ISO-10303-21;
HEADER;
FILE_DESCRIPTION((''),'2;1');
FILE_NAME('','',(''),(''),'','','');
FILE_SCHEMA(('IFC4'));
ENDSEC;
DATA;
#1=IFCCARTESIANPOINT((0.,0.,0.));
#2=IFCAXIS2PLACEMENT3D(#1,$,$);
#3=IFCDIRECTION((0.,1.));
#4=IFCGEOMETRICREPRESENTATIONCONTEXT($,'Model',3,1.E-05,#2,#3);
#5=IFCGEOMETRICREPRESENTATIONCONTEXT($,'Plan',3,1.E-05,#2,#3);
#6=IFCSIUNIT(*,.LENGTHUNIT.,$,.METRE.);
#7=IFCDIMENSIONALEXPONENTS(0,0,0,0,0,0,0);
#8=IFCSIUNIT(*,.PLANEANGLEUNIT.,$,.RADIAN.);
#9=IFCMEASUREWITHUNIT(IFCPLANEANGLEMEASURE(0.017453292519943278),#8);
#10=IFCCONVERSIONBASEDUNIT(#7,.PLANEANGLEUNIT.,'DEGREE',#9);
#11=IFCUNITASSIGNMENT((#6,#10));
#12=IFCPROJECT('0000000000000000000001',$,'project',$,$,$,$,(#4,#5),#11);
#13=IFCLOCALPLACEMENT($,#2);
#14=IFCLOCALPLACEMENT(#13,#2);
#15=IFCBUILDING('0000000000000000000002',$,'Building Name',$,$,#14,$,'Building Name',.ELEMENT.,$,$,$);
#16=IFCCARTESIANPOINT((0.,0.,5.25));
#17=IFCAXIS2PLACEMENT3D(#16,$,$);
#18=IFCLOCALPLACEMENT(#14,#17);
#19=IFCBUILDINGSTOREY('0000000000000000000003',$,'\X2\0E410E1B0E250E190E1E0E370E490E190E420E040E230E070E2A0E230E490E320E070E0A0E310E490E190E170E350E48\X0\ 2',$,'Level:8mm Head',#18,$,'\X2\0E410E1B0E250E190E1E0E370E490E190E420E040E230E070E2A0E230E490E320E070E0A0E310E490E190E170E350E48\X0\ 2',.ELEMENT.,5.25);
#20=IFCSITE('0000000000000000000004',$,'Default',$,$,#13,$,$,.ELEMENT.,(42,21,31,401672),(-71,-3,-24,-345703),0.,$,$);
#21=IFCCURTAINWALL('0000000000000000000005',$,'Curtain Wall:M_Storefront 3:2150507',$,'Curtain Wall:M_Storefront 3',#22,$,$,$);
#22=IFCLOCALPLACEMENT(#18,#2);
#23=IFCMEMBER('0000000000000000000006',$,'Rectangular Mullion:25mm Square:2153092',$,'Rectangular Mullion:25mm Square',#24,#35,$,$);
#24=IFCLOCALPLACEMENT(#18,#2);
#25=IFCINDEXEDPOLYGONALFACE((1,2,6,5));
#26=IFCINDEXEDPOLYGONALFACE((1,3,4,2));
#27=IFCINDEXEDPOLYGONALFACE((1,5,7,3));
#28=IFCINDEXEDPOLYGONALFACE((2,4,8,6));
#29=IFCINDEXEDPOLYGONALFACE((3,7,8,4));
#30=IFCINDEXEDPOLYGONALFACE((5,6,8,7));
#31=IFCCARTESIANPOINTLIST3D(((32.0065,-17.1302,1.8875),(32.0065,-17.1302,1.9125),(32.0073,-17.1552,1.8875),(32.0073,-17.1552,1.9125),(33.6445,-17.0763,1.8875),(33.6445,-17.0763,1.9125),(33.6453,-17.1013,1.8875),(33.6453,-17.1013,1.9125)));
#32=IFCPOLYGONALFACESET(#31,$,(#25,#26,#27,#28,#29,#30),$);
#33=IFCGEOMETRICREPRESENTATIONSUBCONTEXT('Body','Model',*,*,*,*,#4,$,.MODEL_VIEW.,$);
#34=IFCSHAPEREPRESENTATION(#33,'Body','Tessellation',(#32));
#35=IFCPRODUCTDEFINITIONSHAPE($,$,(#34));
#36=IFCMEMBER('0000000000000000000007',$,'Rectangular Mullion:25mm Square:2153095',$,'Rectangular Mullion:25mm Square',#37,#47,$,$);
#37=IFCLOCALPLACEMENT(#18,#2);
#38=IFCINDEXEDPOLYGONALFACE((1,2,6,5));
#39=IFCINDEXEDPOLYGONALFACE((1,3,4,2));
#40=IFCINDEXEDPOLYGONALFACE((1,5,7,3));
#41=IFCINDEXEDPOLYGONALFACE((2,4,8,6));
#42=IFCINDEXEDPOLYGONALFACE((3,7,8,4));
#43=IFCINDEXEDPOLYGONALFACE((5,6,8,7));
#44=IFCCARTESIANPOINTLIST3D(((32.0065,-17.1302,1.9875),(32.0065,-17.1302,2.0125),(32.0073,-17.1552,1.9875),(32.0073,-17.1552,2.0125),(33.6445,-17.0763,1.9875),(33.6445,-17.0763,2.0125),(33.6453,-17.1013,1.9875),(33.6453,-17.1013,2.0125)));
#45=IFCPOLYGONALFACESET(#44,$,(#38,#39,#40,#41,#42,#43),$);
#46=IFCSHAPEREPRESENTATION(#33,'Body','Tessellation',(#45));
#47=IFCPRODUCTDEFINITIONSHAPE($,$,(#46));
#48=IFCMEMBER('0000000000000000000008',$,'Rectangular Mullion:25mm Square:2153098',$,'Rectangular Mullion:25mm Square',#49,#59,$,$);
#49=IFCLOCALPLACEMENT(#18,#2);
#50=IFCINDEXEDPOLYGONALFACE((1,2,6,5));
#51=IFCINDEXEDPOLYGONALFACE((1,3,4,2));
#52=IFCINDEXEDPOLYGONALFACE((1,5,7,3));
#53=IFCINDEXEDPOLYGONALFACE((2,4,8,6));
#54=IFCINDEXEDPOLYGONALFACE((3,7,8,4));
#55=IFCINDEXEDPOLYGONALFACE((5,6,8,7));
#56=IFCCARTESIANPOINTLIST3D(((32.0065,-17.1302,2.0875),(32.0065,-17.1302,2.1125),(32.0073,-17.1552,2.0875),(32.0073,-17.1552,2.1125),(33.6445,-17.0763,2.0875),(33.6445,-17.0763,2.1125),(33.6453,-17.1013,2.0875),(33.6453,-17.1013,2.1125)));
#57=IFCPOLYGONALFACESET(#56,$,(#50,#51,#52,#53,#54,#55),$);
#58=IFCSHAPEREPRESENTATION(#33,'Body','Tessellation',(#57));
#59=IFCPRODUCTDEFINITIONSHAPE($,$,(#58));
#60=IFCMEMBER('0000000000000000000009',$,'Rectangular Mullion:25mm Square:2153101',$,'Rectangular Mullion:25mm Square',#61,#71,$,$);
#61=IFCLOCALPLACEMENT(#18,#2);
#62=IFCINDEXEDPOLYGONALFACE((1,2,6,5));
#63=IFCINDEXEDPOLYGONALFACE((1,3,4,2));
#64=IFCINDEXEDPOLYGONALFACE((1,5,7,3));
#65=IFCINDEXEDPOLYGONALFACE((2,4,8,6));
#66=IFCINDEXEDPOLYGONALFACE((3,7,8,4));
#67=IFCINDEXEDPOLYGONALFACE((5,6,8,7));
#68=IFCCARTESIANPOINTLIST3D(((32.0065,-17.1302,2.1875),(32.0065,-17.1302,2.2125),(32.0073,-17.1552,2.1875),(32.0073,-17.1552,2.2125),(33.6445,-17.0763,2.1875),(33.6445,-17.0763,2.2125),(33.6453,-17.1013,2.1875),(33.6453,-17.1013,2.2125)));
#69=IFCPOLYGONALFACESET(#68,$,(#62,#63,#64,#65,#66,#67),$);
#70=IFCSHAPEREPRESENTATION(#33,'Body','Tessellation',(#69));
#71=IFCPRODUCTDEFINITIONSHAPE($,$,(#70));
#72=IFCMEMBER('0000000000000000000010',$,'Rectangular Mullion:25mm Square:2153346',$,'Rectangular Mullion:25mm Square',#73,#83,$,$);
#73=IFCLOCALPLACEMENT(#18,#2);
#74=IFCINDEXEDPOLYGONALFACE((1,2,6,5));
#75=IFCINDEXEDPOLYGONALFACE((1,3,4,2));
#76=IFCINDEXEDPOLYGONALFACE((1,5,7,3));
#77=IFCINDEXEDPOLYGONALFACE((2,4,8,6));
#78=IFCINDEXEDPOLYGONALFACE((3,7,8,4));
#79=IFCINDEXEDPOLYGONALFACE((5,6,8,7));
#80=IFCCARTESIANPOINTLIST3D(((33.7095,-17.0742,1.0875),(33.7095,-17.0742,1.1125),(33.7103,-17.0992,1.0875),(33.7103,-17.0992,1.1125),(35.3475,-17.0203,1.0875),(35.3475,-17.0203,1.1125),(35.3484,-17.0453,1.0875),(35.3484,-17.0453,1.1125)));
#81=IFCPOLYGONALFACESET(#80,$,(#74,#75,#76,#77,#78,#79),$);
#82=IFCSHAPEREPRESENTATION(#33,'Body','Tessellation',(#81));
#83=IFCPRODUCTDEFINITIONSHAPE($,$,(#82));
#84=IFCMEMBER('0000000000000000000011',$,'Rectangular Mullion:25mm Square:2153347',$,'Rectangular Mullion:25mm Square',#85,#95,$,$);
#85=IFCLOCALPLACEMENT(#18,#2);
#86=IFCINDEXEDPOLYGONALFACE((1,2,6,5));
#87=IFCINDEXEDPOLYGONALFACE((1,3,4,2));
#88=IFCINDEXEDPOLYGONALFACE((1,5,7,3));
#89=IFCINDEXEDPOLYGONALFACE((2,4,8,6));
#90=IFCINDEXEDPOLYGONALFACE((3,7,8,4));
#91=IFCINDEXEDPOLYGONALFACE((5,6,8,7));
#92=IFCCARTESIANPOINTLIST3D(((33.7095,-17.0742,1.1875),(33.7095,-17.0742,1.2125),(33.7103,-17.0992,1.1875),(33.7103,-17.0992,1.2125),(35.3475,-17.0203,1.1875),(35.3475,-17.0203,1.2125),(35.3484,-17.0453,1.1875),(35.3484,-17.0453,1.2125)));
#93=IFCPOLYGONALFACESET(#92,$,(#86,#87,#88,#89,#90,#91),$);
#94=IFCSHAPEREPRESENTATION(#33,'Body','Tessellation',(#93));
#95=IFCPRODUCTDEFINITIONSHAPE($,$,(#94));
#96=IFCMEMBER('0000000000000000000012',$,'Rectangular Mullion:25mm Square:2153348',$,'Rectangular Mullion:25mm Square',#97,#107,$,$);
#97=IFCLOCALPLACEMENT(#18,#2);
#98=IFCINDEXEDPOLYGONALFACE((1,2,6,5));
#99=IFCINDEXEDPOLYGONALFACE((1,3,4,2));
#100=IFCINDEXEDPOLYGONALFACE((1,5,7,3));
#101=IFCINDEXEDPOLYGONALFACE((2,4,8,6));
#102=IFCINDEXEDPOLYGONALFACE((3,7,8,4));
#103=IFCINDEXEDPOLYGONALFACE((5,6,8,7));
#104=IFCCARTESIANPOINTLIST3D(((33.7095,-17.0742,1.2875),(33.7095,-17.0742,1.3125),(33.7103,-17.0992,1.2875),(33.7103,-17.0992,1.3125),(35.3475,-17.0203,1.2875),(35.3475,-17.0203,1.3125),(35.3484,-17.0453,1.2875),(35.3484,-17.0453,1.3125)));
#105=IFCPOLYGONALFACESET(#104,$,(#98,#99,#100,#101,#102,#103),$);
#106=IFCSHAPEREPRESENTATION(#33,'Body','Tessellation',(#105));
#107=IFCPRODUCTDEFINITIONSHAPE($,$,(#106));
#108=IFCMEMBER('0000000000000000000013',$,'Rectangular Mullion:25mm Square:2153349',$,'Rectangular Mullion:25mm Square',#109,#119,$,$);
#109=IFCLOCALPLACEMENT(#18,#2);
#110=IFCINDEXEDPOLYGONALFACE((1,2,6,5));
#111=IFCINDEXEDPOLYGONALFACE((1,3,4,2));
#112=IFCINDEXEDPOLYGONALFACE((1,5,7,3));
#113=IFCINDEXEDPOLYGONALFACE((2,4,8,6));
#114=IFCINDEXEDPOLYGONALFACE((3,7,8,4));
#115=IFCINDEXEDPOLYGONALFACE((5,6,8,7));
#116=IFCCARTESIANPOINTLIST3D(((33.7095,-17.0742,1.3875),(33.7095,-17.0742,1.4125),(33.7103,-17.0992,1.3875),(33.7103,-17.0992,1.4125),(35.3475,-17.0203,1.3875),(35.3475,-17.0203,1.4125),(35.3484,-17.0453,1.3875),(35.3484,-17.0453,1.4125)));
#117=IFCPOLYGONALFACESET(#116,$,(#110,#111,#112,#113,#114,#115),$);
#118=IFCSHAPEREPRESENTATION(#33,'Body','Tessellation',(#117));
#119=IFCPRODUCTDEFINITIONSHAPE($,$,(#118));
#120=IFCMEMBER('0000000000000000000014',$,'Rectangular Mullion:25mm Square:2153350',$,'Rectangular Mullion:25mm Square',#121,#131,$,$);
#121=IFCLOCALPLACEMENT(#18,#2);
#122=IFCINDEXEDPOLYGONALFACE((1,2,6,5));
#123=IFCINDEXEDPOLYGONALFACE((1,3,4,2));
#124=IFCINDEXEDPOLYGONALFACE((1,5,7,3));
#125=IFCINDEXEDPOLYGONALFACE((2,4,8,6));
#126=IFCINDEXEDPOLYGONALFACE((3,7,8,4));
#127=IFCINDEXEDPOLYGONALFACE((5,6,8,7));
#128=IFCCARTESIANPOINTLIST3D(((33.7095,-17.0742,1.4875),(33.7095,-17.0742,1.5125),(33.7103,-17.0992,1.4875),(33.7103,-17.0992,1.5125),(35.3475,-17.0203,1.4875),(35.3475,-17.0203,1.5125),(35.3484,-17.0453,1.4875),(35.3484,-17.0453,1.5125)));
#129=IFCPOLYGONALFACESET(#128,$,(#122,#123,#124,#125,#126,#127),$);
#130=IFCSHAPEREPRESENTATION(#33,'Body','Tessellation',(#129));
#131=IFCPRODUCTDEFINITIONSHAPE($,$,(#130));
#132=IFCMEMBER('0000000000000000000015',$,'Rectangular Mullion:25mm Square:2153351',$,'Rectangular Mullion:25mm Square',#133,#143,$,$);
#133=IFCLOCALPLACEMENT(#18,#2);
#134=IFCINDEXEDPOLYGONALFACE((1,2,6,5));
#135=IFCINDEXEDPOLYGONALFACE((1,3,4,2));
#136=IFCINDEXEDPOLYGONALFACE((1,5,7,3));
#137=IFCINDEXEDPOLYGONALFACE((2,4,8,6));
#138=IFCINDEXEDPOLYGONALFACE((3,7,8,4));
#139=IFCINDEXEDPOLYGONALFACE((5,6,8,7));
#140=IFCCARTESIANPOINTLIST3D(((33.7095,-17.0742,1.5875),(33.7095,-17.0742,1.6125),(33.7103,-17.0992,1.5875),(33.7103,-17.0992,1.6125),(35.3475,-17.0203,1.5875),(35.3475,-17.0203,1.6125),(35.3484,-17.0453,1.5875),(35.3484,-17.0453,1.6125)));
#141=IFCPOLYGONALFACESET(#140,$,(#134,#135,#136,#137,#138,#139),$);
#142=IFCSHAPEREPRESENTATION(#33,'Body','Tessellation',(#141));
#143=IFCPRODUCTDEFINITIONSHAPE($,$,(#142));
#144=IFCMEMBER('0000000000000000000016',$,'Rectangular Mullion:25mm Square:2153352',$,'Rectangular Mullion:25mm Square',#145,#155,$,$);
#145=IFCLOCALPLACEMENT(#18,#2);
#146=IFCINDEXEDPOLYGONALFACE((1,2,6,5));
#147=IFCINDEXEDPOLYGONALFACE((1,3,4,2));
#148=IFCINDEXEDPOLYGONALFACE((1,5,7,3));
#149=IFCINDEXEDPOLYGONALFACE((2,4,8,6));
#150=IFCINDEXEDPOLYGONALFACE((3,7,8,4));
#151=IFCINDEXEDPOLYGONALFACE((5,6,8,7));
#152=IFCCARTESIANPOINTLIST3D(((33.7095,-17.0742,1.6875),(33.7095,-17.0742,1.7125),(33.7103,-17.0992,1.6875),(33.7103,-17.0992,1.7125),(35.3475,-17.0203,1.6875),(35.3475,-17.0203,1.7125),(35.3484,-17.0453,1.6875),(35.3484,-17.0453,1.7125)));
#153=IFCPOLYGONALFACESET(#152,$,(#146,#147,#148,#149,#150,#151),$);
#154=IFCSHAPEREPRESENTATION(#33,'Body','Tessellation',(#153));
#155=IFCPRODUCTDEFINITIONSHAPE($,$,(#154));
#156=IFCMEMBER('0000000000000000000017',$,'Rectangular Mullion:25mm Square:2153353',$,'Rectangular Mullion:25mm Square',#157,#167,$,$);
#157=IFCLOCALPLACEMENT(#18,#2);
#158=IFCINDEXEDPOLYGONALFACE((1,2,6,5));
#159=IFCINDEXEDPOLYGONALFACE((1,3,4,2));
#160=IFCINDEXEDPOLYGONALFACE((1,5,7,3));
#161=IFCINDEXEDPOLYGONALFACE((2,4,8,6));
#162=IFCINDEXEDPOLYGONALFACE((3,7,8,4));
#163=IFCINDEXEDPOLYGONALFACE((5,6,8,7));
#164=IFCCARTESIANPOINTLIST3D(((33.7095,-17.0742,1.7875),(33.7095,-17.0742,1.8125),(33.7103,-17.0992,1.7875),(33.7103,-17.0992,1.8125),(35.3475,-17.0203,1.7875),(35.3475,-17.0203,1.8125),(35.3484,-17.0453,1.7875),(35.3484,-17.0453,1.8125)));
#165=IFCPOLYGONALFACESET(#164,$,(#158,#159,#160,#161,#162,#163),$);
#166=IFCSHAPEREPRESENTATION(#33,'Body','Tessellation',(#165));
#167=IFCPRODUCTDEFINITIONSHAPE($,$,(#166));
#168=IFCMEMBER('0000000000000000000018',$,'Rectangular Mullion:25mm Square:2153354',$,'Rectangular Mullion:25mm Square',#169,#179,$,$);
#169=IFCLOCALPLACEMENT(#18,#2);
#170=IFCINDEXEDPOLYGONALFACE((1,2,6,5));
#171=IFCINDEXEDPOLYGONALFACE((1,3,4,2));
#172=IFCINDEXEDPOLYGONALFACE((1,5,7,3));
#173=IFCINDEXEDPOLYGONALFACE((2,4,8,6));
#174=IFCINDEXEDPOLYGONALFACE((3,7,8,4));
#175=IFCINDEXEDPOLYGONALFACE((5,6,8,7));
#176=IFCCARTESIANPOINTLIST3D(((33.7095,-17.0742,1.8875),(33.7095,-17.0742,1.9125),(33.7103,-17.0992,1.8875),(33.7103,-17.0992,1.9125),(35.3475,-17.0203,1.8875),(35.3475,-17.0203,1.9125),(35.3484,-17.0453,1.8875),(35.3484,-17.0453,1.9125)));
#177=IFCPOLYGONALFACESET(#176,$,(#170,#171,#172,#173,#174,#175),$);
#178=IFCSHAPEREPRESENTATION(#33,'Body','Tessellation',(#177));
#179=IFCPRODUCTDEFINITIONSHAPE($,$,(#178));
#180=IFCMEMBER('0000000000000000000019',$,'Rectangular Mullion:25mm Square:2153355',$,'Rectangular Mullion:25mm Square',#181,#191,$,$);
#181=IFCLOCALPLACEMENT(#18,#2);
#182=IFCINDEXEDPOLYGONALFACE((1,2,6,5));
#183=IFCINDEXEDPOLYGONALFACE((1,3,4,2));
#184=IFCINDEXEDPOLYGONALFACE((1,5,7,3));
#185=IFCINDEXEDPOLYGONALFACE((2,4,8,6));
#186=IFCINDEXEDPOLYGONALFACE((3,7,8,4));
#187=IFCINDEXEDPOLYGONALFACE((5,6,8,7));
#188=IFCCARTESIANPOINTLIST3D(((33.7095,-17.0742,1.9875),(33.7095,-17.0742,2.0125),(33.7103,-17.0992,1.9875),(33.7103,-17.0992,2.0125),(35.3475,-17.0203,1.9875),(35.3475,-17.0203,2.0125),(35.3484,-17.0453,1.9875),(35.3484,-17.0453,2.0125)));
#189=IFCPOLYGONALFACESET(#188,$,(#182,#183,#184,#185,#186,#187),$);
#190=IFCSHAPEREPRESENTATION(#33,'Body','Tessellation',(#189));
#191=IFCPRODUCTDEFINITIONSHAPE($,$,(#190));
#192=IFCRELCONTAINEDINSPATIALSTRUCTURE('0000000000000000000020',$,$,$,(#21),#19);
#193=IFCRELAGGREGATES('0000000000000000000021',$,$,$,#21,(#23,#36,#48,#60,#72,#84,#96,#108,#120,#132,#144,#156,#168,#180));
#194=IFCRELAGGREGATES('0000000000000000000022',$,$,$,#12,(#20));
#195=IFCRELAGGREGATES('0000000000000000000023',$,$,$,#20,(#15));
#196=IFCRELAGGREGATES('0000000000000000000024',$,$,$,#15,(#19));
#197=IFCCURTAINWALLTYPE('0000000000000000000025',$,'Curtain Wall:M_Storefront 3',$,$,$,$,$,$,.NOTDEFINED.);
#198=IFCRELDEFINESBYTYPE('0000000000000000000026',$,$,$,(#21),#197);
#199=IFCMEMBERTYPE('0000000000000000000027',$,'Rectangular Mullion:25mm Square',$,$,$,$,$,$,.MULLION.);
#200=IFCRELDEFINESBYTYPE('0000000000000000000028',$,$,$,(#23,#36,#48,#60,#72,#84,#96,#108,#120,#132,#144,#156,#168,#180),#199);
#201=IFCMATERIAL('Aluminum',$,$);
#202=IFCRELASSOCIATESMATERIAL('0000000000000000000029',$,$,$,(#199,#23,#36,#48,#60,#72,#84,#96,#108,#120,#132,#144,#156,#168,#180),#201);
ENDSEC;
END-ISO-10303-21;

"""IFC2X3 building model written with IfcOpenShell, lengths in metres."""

from ifc_helpers import new_model, entity, si_unit, converted_unit, direction, frame, origin, origin_2d_with_axis, place, context, subcontext, project, spatial, rectangle, extrude, source, transform, mapped, material, type_object, type_shapes, element, aggregate, save


model = new_model("IFC2X3")

# Units and contexts
model_context = context("Model", 3, precision=1e-05, world=origin(), true_north=direction((0.0, 1.0)))
plan_context = context("Plan", 3, precision=1e-05, world=origin(), true_north=direction((0.0, 1.0)))
body_context = subcontext(model_context, "Body", "Model", "MODEL_VIEW")
ifc_project = project(units=[si_unit("LENGTHUNIT", "METRE"), converted_unit("PLANEANGLEUNIT", "DEGREE", entity("IfcPlaneAngleMeasure", 0.017453292519943278), si_unit("PLANEANGLEUNIT", "RADIAN"), dimensions=[0, 0, 0, 0, 0, 0, 0])], contexts=[model_context, plan_context])

# Site, building, storey
site_placement = place(None, origin())
site = spatial("IfcSite", under=ifc_project, at=site_placement, Name="Default", CompositionType="ELEMENT", RefLatitude=(42, 21, 31, 401672), RefLongitude=(-71, -3, -24, -345703), RefElevation=0.0)
building_placement = place(site_placement, origin())
building = spatial("IfcBuilding", under=site, at=building_placement, Name="Building Name", LongName="Building Name", CompositionType="ELEMENT")
storey_placement = place(building_placement, frame((0.0, 0.0, 5.25)))
storey = spatial("IfcBuildingStorey", under=building, at=storey_placement, Name="แปลนพื้นโครงสร้างชั้นที่ 2", ObjectType="Level:8mm Head", LongName="แปลนพื้นโครงสร้างชั้นที่ 2", CompositionType="ELEMENT", Elevation=5.25)

# Curtain wall, members
curtain_wall_type = type_object("IfcCurtainWallType", Name="Curtain Wall:M_Storefront 3", PredefinedType="NOTDEFINED")
curtain_wall_placement = place(storey_placement, frame((0.0, 0.0, -5.25)))
curtain_wall = element("IfcCurtainWall", 1, at=curtain_wall_placement, inside=storey, type_object=curtain_wall_type, Name="Curtain Wall:M_Storefront 3:2150507", ObjectType="Curtain Wall:M_Storefront 3")
ifc_material = material(Name="Aluminum")
member_type_1 = type_object("IfcMemberType", Name="Rectangular Mullion:25mm Square", PredefinedType="MULLION", material=ifc_material)
shared_shape_1 = source(origin(), body_context, "Body", "SweptSolid", [
    extrude(rectangle(XDim=0.025, YDim=0.025, at=origin_2d_with_axis()), frame((0.0, 0.0, -1.6389), z_axis=(0.0, 0.0, 1.0), x_axis=(-1.0, 0.0, 0.0)), (0.0, 0.0, 1.0), 1.6389),
])
type_shapes(member_type_1, [shared_shape_1])
member_1_placement = place(curtain_wall_placement, frame((33.6449, -17.0888, 7.15), z_axis=(0.99946, 0.032862, 0.0), x_axis=(0.0, 0.0, 1.0)))
member_1 = element("IfcMember", 2, at=member_1_placement, type_object=member_type_1, material=ifc_material, Name="Rectangular Mullion:25mm Square:2153092", ObjectType="Rectangular Mullion:25mm Square", context=body_context, shape_type="MappedRepresentation", body=[
    mapped(shared_shape_1, transform((0.0, 0.0, 0.0), scale=1.0)),
])
member_2_placement = place(curtain_wall_placement, frame((33.6449, -17.0888, 7.25), z_axis=(0.99946, 0.032862, 0.0), x_axis=(0.0, 0.0, 1.0)))
member_2 = element("IfcMember", 3, at=member_2_placement, type_object=member_type_1, material=ifc_material, Name="Rectangular Mullion:25mm Square:2153095", ObjectType="Rectangular Mullion:25mm Square", context=body_context, shape_type="MappedRepresentation", body=[
    mapped(shared_shape_1, transform((0.0, 0.0, 0.0), scale=1.0)),
])
member_3_placement = place(curtain_wall_placement, frame((33.6449, -17.0888, 7.35), z_axis=(0.99946, 0.032862, 0.0), x_axis=(0.0, 0.0, 1.0)))
member_3 = element("IfcMember", 4, at=member_3_placement, type_object=member_type_1, material=ifc_material, Name="Rectangular Mullion:25mm Square:2153098", ObjectType="Rectangular Mullion:25mm Square", context=body_context, shape_type="MappedRepresentation", body=[
    mapped(shared_shape_1, transform((0.0, 0.0, 0.0), scale=1.0)),
])
member_4_placement = place(curtain_wall_placement, frame((33.6449, -17.0888, 7.45), z_axis=(0.99946, 0.032862, 0.0), x_axis=(0.0, 0.0, 1.0)))
member_4 = element("IfcMember", 5, at=member_4_placement, type_object=member_type_1, material=ifc_material, Name="Rectangular Mullion:25mm Square:2153101", ObjectType="Rectangular Mullion:25mm Square", context=body_context, shape_type="MappedRepresentation", body=[
    mapped(shared_shape_1, transform((0.0, 0.0, 0.0), scale=1.0)),
])
member_5_placement = place(curtain_wall_placement, frame((35.348, -17.0328, 6.35), z_axis=(0.99946, 0.032862, 0.0), x_axis=(0.0, 0.0, 1.0)))
member_5 = element("IfcMember", 6, at=member_5_placement, type_object=member_type_1, material=ifc_material, Name="Rectangular Mullion:25mm Square:2153346", ObjectType="Rectangular Mullion:25mm Square", context=body_context, shape_type="MappedRepresentation", body=[
    mapped(shared_shape_1, transform((0.0, 0.0, 0.0), scale=1.0)),
])
member_6_placement = place(curtain_wall_placement, frame((35.348, -17.0328, 6.45), z_axis=(0.99946, 0.032862, 0.0), x_axis=(0.0, 0.0, 1.0)))
member_6 = element("IfcMember", 7, at=member_6_placement, type_object=member_type_1, material=ifc_material, Name="Rectangular Mullion:25mm Square:2153347", ObjectType="Rectangular Mullion:25mm Square", context=body_context, shape_type="MappedRepresentation", body=[
    mapped(shared_shape_1, transform((0.0, 0.0, 0.0), scale=1.0)),
])
member_7_placement = place(curtain_wall_placement, frame((35.348, -17.0328, 6.55), z_axis=(0.99946, 0.032862, 0.0), x_axis=(0.0, 0.0, 1.0)))
member_7 = element("IfcMember", 8, at=member_7_placement, type_object=member_type_1, material=ifc_material, Name="Rectangular Mullion:25mm Square:2153348", ObjectType="Rectangular Mullion:25mm Square", context=body_context, shape_type="MappedRepresentation", body=[
    mapped(shared_shape_1, transform((0.0, 0.0, 0.0), scale=1.0)),
])
member_8_placement = place(curtain_wall_placement, frame((35.348, -17.0328, 6.65), z_axis=(0.99946, 0.032862, 0.0), x_axis=(0.0, 0.0, 1.0)))
member_8 = element("IfcMember", 9, at=member_8_placement, type_object=member_type_1, material=ifc_material, Name="Rectangular Mullion:25mm Square:2153349", ObjectType="Rectangular Mullion:25mm Square", context=body_context, shape_type="MappedRepresentation", body=[
    mapped(shared_shape_1, transform((0.0, 0.0, 0.0), scale=1.0)),
])
member_9_placement = place(curtain_wall_placement, frame((35.348, -17.0328, 6.75), z_axis=(0.99946, 0.032862, 0.0), x_axis=(0.0, 0.0, 1.0)))
member_9 = element("IfcMember", 10, at=member_9_placement, type_object=member_type_1, material=ifc_material, Name="Rectangular Mullion:25mm Square:2153350", ObjectType="Rectangular Mullion:25mm Square", context=body_context, shape_type="MappedRepresentation", body=[
    mapped(shared_shape_1, transform((0.0, 0.0, 0.0), scale=1.0)),
])
member_10_placement = place(curtain_wall_placement, frame((35.348, -17.0328, 6.85), z_axis=(0.99946, 0.032862, 0.0), x_axis=(0.0, 0.0, 1.0)))
member_10 = element("IfcMember", 11, at=member_10_placement, type_object=member_type_1, material=ifc_material, Name="Rectangular Mullion:25mm Square:2153351", ObjectType="Rectangular Mullion:25mm Square", context=body_context, shape_type="MappedRepresentation", body=[
    mapped(shared_shape_1, transform((0.0, 0.0, 0.0), scale=1.0)),
])
member_11_placement = place(curtain_wall_placement, frame((35.348, -17.0328, 6.95), z_axis=(0.99946, 0.032862, 0.0), x_axis=(0.0, 0.0, 1.0)))
member_11 = element("IfcMember", 12, at=member_11_placement, type_object=member_type_1, material=ifc_material, Name="Rectangular Mullion:25mm Square:2153352", ObjectType="Rectangular Mullion:25mm Square", context=body_context, shape_type="MappedRepresentation", body=[
    mapped(shared_shape_1, transform((0.0, 0.0, 0.0), scale=1.0)),
])
member_12_placement = place(curtain_wall_placement, frame((35.348, -17.0328, 7.05), z_axis=(0.99946, 0.032862, 0.0), x_axis=(0.0, 0.0, 1.0)))
member_12 = element("IfcMember", 13, at=member_12_placement, type_object=member_type_1, material=ifc_material, Name="Rectangular Mullion:25mm Square:2153353", ObjectType="Rectangular Mullion:25mm Square", context=body_context, shape_type="MappedRepresentation", body=[
    mapped(shared_shape_1, transform((0.0, 0.0, 0.0), scale=1.0)),
])
member_13_placement = place(curtain_wall_placement, frame((35.348, -17.0328, 7.15), z_axis=(0.99946, 0.032862, 0.0), x_axis=(0.0, 0.0, 1.0)))
member_13 = element("IfcMember", 14, at=member_13_placement, type_object=member_type_1, material=ifc_material, Name="Rectangular Mullion:25mm Square:2153354", ObjectType="Rectangular Mullion:25mm Square", context=body_context, shape_type="MappedRepresentation", body=[
    mapped(shared_shape_1, transform((0.0, 0.0, 0.0), scale=1.0)),
])
member_14_placement = place(curtain_wall_placement, frame((35.348, -17.0328, 7.25), z_axis=(0.99946, 0.032862, 0.0), x_axis=(0.0, 0.0, 1.0)))
member_14 = element("IfcMember", 15, at=member_14_placement, type_object=member_type_1, material=ifc_material, Name="Rectangular Mullion:25mm Square:2153355", ObjectType="Rectangular Mullion:25mm Square", context=body_context, shape_type="MappedRepresentation", body=[
    mapped(shared_shape_1, transform((0.0, 0.0, 0.0), scale=1.0)),
])
aggregate(curtain_wall, [member_1, member_2, member_3, member_4, member_5, member_6, member_7, member_8, member_9, member_10, member_11, member_12, member_13, member_14])

save(model, "model.ifc")
